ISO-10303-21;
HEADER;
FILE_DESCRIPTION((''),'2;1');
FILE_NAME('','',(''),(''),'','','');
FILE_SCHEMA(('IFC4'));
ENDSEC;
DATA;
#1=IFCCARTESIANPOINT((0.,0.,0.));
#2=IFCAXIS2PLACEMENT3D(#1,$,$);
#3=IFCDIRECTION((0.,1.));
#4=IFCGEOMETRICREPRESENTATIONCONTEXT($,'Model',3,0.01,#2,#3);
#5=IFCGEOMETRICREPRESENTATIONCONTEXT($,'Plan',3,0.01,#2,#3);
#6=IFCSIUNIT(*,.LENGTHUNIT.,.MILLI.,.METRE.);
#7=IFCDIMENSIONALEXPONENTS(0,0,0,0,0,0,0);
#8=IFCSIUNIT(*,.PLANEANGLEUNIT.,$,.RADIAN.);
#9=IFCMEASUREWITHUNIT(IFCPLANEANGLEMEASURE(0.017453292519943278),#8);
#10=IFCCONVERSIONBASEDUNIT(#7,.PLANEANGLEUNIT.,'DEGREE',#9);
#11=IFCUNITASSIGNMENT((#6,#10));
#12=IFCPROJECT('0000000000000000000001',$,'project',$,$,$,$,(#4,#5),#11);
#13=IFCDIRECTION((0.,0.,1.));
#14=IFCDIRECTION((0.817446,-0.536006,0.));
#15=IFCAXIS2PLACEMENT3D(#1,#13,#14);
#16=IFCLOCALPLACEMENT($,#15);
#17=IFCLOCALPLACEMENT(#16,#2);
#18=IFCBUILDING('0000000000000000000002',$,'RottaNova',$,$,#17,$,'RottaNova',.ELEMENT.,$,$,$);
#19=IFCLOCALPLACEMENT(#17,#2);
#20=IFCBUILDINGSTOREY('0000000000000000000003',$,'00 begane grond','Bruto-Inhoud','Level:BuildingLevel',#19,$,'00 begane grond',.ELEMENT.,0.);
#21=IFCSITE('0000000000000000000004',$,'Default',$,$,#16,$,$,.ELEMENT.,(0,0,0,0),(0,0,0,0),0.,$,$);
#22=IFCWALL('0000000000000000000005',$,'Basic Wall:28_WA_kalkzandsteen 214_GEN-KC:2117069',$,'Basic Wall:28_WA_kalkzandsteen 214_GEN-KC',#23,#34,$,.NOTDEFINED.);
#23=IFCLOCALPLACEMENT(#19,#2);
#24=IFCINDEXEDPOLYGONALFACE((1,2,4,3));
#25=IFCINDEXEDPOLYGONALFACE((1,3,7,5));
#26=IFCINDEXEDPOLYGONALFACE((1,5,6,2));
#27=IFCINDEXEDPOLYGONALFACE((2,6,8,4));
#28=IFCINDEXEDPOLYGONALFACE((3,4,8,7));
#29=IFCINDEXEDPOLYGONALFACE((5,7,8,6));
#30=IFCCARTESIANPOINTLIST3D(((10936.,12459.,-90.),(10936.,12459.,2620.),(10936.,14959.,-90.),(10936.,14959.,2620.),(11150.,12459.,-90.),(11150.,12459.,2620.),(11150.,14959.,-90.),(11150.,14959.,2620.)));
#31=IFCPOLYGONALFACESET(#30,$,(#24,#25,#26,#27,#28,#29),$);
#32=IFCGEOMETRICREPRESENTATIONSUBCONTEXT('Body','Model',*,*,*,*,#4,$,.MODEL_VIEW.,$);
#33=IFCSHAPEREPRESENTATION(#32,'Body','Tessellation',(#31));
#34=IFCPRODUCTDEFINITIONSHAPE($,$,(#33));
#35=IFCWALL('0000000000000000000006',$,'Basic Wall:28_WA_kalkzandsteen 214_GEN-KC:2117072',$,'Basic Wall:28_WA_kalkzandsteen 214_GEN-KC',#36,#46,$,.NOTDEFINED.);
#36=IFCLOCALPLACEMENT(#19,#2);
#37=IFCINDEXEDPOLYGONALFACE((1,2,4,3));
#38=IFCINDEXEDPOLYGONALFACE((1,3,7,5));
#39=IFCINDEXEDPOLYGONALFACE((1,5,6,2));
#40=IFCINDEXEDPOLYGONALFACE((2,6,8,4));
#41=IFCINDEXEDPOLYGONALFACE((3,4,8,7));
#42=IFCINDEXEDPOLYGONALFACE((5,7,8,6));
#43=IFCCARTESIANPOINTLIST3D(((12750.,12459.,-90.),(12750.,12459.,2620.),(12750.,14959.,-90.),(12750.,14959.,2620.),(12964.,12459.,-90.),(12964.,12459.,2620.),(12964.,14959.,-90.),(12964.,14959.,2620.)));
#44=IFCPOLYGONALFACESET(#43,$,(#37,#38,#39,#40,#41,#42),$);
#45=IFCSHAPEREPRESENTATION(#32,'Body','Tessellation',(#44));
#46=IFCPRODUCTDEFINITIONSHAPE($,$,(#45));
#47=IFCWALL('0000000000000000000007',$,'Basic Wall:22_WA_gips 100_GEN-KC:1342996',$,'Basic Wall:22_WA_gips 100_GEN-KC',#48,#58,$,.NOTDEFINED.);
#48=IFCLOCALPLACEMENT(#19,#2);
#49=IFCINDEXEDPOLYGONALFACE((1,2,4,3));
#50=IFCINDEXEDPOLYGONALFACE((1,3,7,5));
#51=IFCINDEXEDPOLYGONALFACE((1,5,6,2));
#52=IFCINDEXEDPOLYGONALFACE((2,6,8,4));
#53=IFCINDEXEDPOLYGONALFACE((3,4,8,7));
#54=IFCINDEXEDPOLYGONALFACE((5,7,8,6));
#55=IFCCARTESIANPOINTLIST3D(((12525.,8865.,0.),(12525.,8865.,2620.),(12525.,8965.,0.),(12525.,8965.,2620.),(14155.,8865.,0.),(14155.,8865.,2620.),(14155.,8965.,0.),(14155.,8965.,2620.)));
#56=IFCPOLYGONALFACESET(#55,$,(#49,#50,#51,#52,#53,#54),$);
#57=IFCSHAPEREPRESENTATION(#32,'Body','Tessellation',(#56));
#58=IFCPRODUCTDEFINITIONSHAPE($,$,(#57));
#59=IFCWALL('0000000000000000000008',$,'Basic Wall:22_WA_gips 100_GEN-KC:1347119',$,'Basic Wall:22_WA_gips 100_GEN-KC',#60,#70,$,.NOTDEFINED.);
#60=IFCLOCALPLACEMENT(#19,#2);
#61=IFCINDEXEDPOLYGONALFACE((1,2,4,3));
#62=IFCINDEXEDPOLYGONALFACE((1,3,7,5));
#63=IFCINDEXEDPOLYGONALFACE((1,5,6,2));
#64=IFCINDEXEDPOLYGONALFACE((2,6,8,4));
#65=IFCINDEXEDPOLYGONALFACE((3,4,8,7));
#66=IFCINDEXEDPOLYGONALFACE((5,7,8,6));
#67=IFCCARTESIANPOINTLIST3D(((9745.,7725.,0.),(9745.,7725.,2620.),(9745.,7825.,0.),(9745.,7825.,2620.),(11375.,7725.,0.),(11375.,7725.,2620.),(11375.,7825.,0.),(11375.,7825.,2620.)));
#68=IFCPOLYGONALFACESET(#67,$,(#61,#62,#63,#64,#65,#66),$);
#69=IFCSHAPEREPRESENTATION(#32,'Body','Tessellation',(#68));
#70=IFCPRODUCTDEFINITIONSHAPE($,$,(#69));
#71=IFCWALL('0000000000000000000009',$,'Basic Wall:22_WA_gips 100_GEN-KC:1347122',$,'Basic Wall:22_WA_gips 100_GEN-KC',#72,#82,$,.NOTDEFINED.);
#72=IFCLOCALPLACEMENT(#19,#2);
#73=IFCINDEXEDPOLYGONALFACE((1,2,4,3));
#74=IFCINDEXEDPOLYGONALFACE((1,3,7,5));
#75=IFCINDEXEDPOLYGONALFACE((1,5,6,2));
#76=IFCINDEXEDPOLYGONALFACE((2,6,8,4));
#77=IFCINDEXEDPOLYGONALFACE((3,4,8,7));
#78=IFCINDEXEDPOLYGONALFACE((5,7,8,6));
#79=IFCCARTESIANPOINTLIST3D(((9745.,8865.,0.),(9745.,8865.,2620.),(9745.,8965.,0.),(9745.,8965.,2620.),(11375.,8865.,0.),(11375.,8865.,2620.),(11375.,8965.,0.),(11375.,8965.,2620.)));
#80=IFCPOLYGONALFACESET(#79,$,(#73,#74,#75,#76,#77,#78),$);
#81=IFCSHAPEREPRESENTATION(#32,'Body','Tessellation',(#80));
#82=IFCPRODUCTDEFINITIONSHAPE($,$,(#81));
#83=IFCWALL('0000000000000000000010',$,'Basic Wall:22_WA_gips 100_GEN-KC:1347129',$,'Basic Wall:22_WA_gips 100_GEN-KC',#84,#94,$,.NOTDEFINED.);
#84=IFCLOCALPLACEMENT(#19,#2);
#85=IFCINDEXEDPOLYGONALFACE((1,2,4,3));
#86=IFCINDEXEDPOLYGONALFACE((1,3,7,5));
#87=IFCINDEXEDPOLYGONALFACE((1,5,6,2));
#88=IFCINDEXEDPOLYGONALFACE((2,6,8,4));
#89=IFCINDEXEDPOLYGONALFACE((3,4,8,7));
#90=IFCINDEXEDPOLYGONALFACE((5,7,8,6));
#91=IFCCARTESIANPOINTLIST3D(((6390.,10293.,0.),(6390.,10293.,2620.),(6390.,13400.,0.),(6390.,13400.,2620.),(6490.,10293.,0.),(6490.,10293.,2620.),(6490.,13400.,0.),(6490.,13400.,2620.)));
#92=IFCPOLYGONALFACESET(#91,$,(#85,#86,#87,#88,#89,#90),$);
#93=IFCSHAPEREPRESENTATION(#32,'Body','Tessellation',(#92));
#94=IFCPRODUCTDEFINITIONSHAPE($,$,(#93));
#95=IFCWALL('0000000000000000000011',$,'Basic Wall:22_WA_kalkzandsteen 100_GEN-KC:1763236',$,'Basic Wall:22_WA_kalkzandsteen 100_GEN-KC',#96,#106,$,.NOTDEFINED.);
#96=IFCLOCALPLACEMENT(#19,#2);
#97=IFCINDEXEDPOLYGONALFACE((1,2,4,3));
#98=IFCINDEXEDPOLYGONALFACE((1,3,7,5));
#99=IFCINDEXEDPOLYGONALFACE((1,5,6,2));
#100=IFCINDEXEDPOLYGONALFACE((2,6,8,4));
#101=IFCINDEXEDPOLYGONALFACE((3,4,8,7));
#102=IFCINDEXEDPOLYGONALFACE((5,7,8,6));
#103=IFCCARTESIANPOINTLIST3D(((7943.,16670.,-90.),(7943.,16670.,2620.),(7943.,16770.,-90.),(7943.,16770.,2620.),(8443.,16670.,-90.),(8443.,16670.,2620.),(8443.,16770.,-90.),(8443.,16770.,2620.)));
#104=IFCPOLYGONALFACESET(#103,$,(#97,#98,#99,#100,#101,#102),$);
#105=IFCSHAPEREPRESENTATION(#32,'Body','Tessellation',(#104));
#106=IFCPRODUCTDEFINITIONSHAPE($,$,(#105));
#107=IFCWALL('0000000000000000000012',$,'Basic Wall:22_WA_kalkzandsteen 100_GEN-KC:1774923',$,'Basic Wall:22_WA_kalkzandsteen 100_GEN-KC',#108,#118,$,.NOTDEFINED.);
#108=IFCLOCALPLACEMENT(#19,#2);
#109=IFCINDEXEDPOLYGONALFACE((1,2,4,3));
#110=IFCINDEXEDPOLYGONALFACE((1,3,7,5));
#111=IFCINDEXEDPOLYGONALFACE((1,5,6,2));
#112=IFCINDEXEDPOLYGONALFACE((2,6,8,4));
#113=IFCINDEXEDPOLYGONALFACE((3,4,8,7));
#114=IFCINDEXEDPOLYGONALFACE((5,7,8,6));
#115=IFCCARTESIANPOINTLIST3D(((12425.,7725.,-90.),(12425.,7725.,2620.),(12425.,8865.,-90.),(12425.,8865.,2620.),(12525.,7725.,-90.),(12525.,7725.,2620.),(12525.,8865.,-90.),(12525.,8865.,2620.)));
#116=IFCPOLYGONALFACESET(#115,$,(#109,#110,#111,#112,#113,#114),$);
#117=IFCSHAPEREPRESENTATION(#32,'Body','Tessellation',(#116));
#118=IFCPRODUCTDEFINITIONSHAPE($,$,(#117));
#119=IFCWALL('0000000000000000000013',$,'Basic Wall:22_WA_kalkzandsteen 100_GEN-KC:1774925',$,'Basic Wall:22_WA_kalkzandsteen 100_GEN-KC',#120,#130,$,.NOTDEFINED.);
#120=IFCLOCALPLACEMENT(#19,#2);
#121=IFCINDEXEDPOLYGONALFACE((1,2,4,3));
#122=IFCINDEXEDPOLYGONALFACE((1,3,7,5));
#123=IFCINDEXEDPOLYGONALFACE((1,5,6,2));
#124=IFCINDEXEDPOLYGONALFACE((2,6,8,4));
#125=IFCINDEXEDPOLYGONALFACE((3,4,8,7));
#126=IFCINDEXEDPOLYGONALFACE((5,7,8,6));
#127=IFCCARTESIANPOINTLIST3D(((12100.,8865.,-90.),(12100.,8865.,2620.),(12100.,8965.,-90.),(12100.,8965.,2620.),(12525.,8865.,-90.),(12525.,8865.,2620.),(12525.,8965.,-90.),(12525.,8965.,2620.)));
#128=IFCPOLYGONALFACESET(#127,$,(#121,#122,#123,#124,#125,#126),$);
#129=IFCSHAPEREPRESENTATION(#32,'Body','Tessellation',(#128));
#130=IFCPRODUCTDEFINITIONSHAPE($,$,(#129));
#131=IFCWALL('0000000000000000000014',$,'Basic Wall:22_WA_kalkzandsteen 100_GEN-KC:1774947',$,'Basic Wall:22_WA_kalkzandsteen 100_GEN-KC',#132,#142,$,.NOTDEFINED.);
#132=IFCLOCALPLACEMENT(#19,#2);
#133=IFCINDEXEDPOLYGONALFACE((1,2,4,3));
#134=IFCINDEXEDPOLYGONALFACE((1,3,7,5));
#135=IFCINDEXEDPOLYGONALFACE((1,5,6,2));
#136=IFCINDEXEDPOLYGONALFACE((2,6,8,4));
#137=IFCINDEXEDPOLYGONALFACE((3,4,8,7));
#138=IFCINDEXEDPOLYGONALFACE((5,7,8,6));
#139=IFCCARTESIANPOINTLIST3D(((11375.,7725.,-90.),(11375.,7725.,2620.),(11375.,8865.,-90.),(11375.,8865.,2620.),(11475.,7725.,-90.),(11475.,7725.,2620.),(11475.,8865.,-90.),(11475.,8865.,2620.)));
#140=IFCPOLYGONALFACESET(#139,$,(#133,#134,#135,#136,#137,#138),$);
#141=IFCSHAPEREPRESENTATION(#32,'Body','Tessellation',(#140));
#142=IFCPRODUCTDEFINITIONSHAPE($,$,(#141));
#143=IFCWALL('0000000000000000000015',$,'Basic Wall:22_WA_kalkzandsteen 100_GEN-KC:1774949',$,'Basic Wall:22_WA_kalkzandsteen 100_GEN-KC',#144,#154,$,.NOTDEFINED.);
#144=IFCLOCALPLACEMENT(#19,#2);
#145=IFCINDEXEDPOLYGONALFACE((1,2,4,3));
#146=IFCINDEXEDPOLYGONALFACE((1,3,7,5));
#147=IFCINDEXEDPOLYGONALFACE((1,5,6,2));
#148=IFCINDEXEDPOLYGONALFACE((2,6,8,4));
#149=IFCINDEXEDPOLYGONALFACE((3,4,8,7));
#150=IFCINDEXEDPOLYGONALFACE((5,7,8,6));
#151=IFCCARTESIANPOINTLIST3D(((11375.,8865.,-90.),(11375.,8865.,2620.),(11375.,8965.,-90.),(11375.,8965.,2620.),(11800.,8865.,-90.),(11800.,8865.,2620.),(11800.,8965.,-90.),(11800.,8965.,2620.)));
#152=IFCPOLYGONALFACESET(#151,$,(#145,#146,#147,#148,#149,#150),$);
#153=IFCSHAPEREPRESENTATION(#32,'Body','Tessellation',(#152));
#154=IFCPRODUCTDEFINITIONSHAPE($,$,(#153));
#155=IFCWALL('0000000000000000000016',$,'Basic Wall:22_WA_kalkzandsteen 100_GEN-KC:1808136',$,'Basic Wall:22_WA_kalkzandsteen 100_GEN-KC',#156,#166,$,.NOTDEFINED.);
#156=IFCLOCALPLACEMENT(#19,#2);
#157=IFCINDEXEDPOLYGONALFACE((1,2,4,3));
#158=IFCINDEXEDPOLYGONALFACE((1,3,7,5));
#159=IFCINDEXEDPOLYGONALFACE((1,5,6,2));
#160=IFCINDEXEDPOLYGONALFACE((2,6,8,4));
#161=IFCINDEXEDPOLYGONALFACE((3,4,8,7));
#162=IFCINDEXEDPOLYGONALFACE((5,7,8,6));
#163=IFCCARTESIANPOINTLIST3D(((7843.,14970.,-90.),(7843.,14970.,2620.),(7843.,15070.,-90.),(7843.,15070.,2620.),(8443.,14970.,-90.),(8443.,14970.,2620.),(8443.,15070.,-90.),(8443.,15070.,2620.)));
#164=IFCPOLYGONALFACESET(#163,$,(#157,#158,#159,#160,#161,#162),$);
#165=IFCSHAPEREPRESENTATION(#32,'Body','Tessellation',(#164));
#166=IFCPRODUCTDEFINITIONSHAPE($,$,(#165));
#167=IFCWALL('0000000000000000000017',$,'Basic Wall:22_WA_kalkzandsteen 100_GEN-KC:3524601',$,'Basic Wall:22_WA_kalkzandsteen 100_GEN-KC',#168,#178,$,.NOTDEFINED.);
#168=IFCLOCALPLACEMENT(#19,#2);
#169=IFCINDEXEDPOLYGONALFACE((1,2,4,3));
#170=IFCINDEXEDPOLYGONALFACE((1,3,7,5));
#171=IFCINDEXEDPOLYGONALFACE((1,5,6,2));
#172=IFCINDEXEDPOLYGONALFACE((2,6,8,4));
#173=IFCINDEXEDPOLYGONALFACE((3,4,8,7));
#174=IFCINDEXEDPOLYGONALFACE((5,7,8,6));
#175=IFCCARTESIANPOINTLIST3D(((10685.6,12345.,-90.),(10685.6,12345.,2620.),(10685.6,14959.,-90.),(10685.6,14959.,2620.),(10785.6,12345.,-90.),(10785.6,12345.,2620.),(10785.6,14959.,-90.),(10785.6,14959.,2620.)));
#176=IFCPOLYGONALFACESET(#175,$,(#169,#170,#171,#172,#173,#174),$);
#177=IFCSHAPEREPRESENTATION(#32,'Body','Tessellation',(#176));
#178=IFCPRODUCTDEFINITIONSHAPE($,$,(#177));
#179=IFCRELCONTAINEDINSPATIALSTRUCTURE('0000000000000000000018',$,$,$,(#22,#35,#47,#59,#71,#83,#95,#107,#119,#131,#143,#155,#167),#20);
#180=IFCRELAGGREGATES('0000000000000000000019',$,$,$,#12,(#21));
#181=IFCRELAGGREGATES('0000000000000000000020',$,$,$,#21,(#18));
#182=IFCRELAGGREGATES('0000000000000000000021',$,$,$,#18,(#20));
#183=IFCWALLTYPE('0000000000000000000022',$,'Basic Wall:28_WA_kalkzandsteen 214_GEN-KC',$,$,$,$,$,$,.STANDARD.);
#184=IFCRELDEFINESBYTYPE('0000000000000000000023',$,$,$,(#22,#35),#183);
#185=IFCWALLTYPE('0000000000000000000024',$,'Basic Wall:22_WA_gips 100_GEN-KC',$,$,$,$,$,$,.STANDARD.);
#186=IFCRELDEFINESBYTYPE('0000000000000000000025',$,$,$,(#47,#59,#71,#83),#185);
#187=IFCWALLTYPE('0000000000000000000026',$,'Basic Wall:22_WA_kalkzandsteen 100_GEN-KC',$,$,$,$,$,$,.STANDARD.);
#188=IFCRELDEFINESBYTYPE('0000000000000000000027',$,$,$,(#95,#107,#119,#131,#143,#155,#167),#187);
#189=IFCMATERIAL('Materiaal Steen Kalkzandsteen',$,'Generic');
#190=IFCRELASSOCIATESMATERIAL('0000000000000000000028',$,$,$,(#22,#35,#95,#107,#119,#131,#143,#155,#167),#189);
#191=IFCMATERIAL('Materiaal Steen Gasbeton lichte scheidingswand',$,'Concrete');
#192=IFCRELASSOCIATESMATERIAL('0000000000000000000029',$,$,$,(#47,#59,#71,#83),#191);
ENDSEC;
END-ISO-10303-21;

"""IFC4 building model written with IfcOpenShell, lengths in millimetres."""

from ifc_helpers import new_model, entity, si_unit, converted_unit, direction, frame, origin, place, context, subcontext, project, spatial, indexed_curve, outline, extrude, material, type_object, element, save


model = new_model("IFC4")

# Units and contexts
model_context = context("Model", 3, precision=0.01, world=origin(), true_north=direction((0.0, 1.0)))
plan_context = context("Plan", 3, precision=0.01, world=origin(), true_north=direction((0.0, 1.0)))
body_context = subcontext(model_context, "Body", "Model", "MODEL_VIEW")
ifc_project = project(units=[si_unit("LENGTHUNIT", "METRE", prefix="MILLI"), converted_unit("PLANEANGLEUNIT", "DEGREE", entity("IfcPlaneAngleMeasure", 0.017453292519943278), si_unit("PLANEANGLEUNIT", "RADIAN"), dimensions=[0, 0, 0, 0, 0, 0, 0])], contexts=[model_context, plan_context])

# Site, building, storey
site_placement = place(None, frame((0.0, 0.0, 0.0), z_axis=(0.0, 0.0, 1.0), x_axis=(0.817446, -0.536006, 0.0)))
site = spatial("IfcSite", under=ifc_project, at=site_placement, Name="Default", CompositionType="ELEMENT", RefLatitude=(0, 0, 0, 0), RefLongitude=(0, 0, 0, 0), RefElevation=0.0)
building_placement = place(site_placement, origin())
building = spatial("IfcBuilding", under=site, at=building_placement, Name="RottaNova", LongName="RottaNova", CompositionType="ELEMENT")
storey_placement = place(building_placement, origin())
storey = spatial("IfcBuildingStorey", under=building, at=storey_placement, Name="00 begane grond", Description="Bruto-Inhoud", ObjectType="Level:BuildingLevel", LongName="00 begane grond", CompositionType="ELEMENT", Elevation=0.0)

# Walls
ifc_material_1 = material(Name="Materiaal Steen Kalkzandsteen", Category="Generic")
wall_type_1 = type_object("IfcWallType", Name="Basic Wall:28_WA_kalkzandsteen 214_GEN-KC", PredefinedType="STANDARD")
wall_1_placement = place(storey_placement, frame((11043.0, 12459.0, -90.0), z_axis=(0.0, 0.0, 1.0), x_axis=(0.0, 1.0, 0.0)))
element("IfcWall", 1, at=wall_1_placement, inside=storey, type_object=wall_type_1, material=ifc_material_1, Name="Basic Wall:28_WA_kalkzandsteen 214_GEN-KC:2117069", ObjectType="Basic Wall:28_WA_kalkzandsteen 214_GEN-KC", PredefinedType="NOTDEFINED", context=body_context, shape_type="SweptSolid", body=[
    extrude(outline(indexed_curve([(2500.0, 107.0), (0.0, 107.0), (0.0, -107.0), (2500.0, -107.0), (2500.0, 107.0)], self_intersect=False)), origin(), (0.0, 0.0, 1.0), 2710.0),
])
wall_2_placement = place(storey_placement, frame((12857.0, 12459.0, -90.0), z_axis=(0.0, 0.0, 1.0), x_axis=(0.0, 1.0, 0.0)))
element("IfcWall", 2, at=wall_2_placement, inside=storey, type_object=wall_type_1, material=ifc_material_1, Name="Basic Wall:28_WA_kalkzandsteen 214_GEN-KC:2117072", ObjectType="Basic Wall:28_WA_kalkzandsteen 214_GEN-KC", PredefinedType="NOTDEFINED", context=body_context, shape_type="SweptSolid", body=[
    extrude(outline(indexed_curve([(2500.0, 107.0), (0.0, 107.0), (0.0, -107.0), (2500.0, -107.0), (2500.0, 107.0)], self_intersect=False)), origin(), (0.0, 0.0, 1.0), 2710.0),
])
ifc_material_2 = material(Name="Materiaal Steen Gasbeton lichte scheidingswand", Category="Concrete")
wall_type_2 = type_object("IfcWallType", Name="Basic Wall:22_WA_gips 100_GEN-KC", PredefinedType="STANDARD")
wall_3_placement = place(storey_placement, frame((12525.0, 8915.0, 0.0)))
element("IfcWall", 3, at=wall_3_placement, inside=storey, type_object=wall_type_2, material=ifc_material_2, Name="Basic Wall:22_WA_gips 100_GEN-KC:1342996", ObjectType="Basic Wall:22_WA_gips 100_GEN-KC", PredefinedType="NOTDEFINED", context=body_context, shape_type="SweptSolid", body=[
    extrude(outline(indexed_curve([(1630.0, 50.0), (0.0, 50.0), (0.0, -50.0), (1630.0, -50.0), (1630.0, 50.0)], self_intersect=False)), origin(), (0.0, 0.0, 1.0), 2620.0),
])
wall_4_placement = place(storey_placement, frame((9745.0, 7775.0, 0.0)))
element("IfcWall", 4, at=wall_4_placement, inside=storey, type_object=wall_type_2, material=ifc_material_2, Name="Basic Wall:22_WA_gips 100_GEN-KC:1347119", ObjectType="Basic Wall:22_WA_gips 100_GEN-KC", PredefinedType="NOTDEFINED", context=body_context, shape_type="SweptSolid", body=[
    extrude(outline(indexed_curve([(1630.0, 50.0), (0.0, 50.0), (0.0, -50.0), (1630.0, -50.0), (1630.0, 50.0)], self_intersect=False)), origin(), (0.0, 0.0, 1.0), 2620.0),
])
wall_5_placement = place(storey_placement, frame((11375.0, 8915.0, 0.0), z_axis=(0.0, 0.0, 1.0), x_axis=(-1.0, 0.0, 0.0)))
element("IfcWall", 5, at=wall_5_placement, inside=storey, type_object=wall_type_2, material=ifc_material_2, Name="Basic Wall:22_WA_gips 100_GEN-KC:1347122", ObjectType="Basic Wall:22_WA_gips 100_GEN-KC", PredefinedType="NOTDEFINED", context=body_context, shape_type="SweptSolid", body=[
    extrude(outline(indexed_curve([(1630.0, 50.0), (0.0, 50.0), (0.0, -50.0), (1630.0, -50.0), (1630.0, 50.0)], self_intersect=False)), origin(), (0.0, 0.0, 1.0), 2620.0),
])
wall_6_placement = place(storey_placement, frame((6440.0, 13400.0, 0.0), z_axis=(0.0, 0.0, 1.0), x_axis=(0.0, -1.0, 0.0)))
element("IfcWall", 6, at=wall_6_placement, inside=storey, type_object=wall_type_2, material=ifc_material_2, Name="Basic Wall:22_WA_gips 100_GEN-KC:1347129", ObjectType="Basic Wall:22_WA_gips 100_GEN-KC", PredefinedType="NOTDEFINED", context=body_context, shape_type="SweptSolid", body=[
    extrude(outline(indexed_curve([(3107.0, 50.0), (0.0, 50.0), (0.0, -50.0), (3107.0, -50.0), (3107.0, 50.0)], self_intersect=False)), origin(), (0.0, 0.0, 1.0), 2620.0),
])

# Walls
wall_type_3 = type_object("IfcWallType", Name="Basic Wall:22_WA_kalkzandsteen 100_GEN-KC", PredefinedType="STANDARD")
wall_7_placement = place(storey_placement, frame((8443.0, 16720.0, -90.0), z_axis=(0.0, 0.0, 1.0), x_axis=(-1.0, 0.0, 0.0)))
element("IfcWall", 7, at=wall_7_placement, inside=storey, type_object=wall_type_3, material=ifc_material_1, Name="Basic Wall:22_WA_kalkzandsteen 100_GEN-KC:1763236", ObjectType="Basic Wall:22_WA_kalkzandsteen 100_GEN-KC", PredefinedType="NOTDEFINED", context=body_context, shape_type="SweptSolid", body=[
    extrude(outline(indexed_curve([(500.0, 50.0), (0.0, 50.0), (0.0, -50.0), (500.0, -50.0), (500.0, 50.0)], self_intersect=False)), origin(), (0.0, 0.0, 1.0), 2710.0),
])
wall_8_placement = place(storey_placement, frame((12475.0, 8865.0, -90.0), z_axis=(0.0, 0.0, 1.0), x_axis=(0.0, -1.0, 0.0)))
element("IfcWall", 8, at=wall_8_placement, inside=storey, type_object=wall_type_3, material=ifc_material_1, Name="Basic Wall:22_WA_kalkzandsteen 100_GEN-KC:1774923", ObjectType="Basic Wall:22_WA_kalkzandsteen 100_GEN-KC", PredefinedType="NOTDEFINED", context=body_context, shape_type="SweptSolid", body=[
    extrude(outline(indexed_curve([(1140.0, 50.0), (0.0, 50.0), (0.0, -50.0), (1140.0, -50.0), (1140.0, 50.0)], self_intersect=False)), origin(), (0.0, 0.0, 1.0), 2710.0),
])
wall_9_placement = place(storey_placement, frame((12100.0, 8915.0, -90.0)))
element("IfcWall", 9, at=wall_9_placement, inside=storey, type_object=wall_type_3, material=ifc_material_1, Name="Basic Wall:22_WA_kalkzandsteen 100_GEN-KC:1774925", ObjectType="Basic Wall:22_WA_kalkzandsteen 100_GEN-KC", PredefinedType="NOTDEFINED", context=body_context, shape_type="SweptSolid", body=[
    extrude(outline(indexed_curve([(425.0, 50.0), (0.0, 50.0), (0.0, -50.0), (425.0, -50.0), (425.0, 50.0)], self_intersect=False)), origin(), (0.0, 0.0, 1.0), 2710.0),
])
wall_10_placement = place(storey_placement, frame((11425.0, 8865.0, -90.0), z_axis=(0.0, 0.0, 1.0), x_axis=(0.0, -1.0, 0.0)))
element("IfcWall", 10, at=wall_10_placement, inside=storey, type_object=wall_type_3, material=ifc_material_1, Name="Basic Wall:22_WA_kalkzandsteen 100_GEN-KC:1774947", ObjectType="Basic Wall:22_WA_kalkzandsteen 100_GEN-KC", PredefinedType="NOTDEFINED", context=body_context, shape_type="SweptSolid", body=[
    extrude(outline(indexed_curve([(1140.0, 50.0), (0.0, 50.0), (0.0, -50.0), (1140.0, -50.0), (1140.0, 50.0)], self_intersect=False)), origin(), (0.0, 0.0, 1.0), 2710.0),
])
wall_11_placement = place(storey_placement, frame((11800.0, 8915.0, -90.0), z_axis=(0.0, 0.0, 1.0), x_axis=(-1.0, 0.0, 0.0)))
element("IfcWall", 11, at=wall_11_placement, inside=storey, type_object=wall_type_3, material=ifc_material_1, Name="Basic Wall:22_WA_kalkzandsteen 100_GEN-KC:1774949", ObjectType="Basic Wall:22_WA_kalkzandsteen 100_GEN-KC", PredefinedType="NOTDEFINED", context=body_context, shape_type="SweptSolid", body=[
    extrude(outline(indexed_curve([(425.0, 50.0), (0.0, 50.0), (0.0, -50.0), (425.0, -50.0), (425.0, 50.0)], self_intersect=False)), origin(), (0.0, 0.0, 1.0), 2710.0),
])
wall_12_placement = place(storey_placement, frame((8443.0, 15020.0, -90.0), z_axis=(0.0, 0.0, 1.0), x_axis=(-1.0, 0.0, 0.0)))
element("IfcWall", 12, at=wall_12_placement, inside=storey, type_object=wall_type_3, material=ifc_material_1, Name="Basic Wall:22_WA_kalkzandsteen 100_GEN-KC:1808136", ObjectType="Basic Wall:22_WA_kalkzandsteen 100_GEN-KC", PredefinedType="NOTDEFINED", context=body_context, shape_type="SweptSolid", body=[
    extrude(outline(indexed_curve([(600.0, 50.0), (0.0, 50.0), (0.0, -50.0), (600.0, -50.0), (600.0, 50.0)], self_intersect=False)), origin(), (0.0, 0.0, 1.0), 2710.0),
])
wall_13_placement = place(storey_placement, frame((10735.6, 14959.0, -90.0), z_axis=(0.0, 0.0, 1.0), x_axis=(0.0, -1.0, 0.0)))
element("IfcWall", 13, at=wall_13_placement, inside=storey, type_object=wall_type_3, material=ifc_material_1, Name="Basic Wall:22_WA_kalkzandsteen 100_GEN-KC:3524601", ObjectType="Basic Wall:22_WA_kalkzandsteen 100_GEN-KC", PredefinedType="NOTDEFINED", context=body_context, shape_type="SweptSolid", body=[
    extrude(outline(indexed_curve([(2614.0, 50.0), (0.0, 50.0), (0.0, -50.0), (2614.0, -50.0), (2614.0, 50.0)], self_intersect=False)), origin(), (0.0, 0.0, 1.0), 2710.0),
])

save(model, "model.ifc")
